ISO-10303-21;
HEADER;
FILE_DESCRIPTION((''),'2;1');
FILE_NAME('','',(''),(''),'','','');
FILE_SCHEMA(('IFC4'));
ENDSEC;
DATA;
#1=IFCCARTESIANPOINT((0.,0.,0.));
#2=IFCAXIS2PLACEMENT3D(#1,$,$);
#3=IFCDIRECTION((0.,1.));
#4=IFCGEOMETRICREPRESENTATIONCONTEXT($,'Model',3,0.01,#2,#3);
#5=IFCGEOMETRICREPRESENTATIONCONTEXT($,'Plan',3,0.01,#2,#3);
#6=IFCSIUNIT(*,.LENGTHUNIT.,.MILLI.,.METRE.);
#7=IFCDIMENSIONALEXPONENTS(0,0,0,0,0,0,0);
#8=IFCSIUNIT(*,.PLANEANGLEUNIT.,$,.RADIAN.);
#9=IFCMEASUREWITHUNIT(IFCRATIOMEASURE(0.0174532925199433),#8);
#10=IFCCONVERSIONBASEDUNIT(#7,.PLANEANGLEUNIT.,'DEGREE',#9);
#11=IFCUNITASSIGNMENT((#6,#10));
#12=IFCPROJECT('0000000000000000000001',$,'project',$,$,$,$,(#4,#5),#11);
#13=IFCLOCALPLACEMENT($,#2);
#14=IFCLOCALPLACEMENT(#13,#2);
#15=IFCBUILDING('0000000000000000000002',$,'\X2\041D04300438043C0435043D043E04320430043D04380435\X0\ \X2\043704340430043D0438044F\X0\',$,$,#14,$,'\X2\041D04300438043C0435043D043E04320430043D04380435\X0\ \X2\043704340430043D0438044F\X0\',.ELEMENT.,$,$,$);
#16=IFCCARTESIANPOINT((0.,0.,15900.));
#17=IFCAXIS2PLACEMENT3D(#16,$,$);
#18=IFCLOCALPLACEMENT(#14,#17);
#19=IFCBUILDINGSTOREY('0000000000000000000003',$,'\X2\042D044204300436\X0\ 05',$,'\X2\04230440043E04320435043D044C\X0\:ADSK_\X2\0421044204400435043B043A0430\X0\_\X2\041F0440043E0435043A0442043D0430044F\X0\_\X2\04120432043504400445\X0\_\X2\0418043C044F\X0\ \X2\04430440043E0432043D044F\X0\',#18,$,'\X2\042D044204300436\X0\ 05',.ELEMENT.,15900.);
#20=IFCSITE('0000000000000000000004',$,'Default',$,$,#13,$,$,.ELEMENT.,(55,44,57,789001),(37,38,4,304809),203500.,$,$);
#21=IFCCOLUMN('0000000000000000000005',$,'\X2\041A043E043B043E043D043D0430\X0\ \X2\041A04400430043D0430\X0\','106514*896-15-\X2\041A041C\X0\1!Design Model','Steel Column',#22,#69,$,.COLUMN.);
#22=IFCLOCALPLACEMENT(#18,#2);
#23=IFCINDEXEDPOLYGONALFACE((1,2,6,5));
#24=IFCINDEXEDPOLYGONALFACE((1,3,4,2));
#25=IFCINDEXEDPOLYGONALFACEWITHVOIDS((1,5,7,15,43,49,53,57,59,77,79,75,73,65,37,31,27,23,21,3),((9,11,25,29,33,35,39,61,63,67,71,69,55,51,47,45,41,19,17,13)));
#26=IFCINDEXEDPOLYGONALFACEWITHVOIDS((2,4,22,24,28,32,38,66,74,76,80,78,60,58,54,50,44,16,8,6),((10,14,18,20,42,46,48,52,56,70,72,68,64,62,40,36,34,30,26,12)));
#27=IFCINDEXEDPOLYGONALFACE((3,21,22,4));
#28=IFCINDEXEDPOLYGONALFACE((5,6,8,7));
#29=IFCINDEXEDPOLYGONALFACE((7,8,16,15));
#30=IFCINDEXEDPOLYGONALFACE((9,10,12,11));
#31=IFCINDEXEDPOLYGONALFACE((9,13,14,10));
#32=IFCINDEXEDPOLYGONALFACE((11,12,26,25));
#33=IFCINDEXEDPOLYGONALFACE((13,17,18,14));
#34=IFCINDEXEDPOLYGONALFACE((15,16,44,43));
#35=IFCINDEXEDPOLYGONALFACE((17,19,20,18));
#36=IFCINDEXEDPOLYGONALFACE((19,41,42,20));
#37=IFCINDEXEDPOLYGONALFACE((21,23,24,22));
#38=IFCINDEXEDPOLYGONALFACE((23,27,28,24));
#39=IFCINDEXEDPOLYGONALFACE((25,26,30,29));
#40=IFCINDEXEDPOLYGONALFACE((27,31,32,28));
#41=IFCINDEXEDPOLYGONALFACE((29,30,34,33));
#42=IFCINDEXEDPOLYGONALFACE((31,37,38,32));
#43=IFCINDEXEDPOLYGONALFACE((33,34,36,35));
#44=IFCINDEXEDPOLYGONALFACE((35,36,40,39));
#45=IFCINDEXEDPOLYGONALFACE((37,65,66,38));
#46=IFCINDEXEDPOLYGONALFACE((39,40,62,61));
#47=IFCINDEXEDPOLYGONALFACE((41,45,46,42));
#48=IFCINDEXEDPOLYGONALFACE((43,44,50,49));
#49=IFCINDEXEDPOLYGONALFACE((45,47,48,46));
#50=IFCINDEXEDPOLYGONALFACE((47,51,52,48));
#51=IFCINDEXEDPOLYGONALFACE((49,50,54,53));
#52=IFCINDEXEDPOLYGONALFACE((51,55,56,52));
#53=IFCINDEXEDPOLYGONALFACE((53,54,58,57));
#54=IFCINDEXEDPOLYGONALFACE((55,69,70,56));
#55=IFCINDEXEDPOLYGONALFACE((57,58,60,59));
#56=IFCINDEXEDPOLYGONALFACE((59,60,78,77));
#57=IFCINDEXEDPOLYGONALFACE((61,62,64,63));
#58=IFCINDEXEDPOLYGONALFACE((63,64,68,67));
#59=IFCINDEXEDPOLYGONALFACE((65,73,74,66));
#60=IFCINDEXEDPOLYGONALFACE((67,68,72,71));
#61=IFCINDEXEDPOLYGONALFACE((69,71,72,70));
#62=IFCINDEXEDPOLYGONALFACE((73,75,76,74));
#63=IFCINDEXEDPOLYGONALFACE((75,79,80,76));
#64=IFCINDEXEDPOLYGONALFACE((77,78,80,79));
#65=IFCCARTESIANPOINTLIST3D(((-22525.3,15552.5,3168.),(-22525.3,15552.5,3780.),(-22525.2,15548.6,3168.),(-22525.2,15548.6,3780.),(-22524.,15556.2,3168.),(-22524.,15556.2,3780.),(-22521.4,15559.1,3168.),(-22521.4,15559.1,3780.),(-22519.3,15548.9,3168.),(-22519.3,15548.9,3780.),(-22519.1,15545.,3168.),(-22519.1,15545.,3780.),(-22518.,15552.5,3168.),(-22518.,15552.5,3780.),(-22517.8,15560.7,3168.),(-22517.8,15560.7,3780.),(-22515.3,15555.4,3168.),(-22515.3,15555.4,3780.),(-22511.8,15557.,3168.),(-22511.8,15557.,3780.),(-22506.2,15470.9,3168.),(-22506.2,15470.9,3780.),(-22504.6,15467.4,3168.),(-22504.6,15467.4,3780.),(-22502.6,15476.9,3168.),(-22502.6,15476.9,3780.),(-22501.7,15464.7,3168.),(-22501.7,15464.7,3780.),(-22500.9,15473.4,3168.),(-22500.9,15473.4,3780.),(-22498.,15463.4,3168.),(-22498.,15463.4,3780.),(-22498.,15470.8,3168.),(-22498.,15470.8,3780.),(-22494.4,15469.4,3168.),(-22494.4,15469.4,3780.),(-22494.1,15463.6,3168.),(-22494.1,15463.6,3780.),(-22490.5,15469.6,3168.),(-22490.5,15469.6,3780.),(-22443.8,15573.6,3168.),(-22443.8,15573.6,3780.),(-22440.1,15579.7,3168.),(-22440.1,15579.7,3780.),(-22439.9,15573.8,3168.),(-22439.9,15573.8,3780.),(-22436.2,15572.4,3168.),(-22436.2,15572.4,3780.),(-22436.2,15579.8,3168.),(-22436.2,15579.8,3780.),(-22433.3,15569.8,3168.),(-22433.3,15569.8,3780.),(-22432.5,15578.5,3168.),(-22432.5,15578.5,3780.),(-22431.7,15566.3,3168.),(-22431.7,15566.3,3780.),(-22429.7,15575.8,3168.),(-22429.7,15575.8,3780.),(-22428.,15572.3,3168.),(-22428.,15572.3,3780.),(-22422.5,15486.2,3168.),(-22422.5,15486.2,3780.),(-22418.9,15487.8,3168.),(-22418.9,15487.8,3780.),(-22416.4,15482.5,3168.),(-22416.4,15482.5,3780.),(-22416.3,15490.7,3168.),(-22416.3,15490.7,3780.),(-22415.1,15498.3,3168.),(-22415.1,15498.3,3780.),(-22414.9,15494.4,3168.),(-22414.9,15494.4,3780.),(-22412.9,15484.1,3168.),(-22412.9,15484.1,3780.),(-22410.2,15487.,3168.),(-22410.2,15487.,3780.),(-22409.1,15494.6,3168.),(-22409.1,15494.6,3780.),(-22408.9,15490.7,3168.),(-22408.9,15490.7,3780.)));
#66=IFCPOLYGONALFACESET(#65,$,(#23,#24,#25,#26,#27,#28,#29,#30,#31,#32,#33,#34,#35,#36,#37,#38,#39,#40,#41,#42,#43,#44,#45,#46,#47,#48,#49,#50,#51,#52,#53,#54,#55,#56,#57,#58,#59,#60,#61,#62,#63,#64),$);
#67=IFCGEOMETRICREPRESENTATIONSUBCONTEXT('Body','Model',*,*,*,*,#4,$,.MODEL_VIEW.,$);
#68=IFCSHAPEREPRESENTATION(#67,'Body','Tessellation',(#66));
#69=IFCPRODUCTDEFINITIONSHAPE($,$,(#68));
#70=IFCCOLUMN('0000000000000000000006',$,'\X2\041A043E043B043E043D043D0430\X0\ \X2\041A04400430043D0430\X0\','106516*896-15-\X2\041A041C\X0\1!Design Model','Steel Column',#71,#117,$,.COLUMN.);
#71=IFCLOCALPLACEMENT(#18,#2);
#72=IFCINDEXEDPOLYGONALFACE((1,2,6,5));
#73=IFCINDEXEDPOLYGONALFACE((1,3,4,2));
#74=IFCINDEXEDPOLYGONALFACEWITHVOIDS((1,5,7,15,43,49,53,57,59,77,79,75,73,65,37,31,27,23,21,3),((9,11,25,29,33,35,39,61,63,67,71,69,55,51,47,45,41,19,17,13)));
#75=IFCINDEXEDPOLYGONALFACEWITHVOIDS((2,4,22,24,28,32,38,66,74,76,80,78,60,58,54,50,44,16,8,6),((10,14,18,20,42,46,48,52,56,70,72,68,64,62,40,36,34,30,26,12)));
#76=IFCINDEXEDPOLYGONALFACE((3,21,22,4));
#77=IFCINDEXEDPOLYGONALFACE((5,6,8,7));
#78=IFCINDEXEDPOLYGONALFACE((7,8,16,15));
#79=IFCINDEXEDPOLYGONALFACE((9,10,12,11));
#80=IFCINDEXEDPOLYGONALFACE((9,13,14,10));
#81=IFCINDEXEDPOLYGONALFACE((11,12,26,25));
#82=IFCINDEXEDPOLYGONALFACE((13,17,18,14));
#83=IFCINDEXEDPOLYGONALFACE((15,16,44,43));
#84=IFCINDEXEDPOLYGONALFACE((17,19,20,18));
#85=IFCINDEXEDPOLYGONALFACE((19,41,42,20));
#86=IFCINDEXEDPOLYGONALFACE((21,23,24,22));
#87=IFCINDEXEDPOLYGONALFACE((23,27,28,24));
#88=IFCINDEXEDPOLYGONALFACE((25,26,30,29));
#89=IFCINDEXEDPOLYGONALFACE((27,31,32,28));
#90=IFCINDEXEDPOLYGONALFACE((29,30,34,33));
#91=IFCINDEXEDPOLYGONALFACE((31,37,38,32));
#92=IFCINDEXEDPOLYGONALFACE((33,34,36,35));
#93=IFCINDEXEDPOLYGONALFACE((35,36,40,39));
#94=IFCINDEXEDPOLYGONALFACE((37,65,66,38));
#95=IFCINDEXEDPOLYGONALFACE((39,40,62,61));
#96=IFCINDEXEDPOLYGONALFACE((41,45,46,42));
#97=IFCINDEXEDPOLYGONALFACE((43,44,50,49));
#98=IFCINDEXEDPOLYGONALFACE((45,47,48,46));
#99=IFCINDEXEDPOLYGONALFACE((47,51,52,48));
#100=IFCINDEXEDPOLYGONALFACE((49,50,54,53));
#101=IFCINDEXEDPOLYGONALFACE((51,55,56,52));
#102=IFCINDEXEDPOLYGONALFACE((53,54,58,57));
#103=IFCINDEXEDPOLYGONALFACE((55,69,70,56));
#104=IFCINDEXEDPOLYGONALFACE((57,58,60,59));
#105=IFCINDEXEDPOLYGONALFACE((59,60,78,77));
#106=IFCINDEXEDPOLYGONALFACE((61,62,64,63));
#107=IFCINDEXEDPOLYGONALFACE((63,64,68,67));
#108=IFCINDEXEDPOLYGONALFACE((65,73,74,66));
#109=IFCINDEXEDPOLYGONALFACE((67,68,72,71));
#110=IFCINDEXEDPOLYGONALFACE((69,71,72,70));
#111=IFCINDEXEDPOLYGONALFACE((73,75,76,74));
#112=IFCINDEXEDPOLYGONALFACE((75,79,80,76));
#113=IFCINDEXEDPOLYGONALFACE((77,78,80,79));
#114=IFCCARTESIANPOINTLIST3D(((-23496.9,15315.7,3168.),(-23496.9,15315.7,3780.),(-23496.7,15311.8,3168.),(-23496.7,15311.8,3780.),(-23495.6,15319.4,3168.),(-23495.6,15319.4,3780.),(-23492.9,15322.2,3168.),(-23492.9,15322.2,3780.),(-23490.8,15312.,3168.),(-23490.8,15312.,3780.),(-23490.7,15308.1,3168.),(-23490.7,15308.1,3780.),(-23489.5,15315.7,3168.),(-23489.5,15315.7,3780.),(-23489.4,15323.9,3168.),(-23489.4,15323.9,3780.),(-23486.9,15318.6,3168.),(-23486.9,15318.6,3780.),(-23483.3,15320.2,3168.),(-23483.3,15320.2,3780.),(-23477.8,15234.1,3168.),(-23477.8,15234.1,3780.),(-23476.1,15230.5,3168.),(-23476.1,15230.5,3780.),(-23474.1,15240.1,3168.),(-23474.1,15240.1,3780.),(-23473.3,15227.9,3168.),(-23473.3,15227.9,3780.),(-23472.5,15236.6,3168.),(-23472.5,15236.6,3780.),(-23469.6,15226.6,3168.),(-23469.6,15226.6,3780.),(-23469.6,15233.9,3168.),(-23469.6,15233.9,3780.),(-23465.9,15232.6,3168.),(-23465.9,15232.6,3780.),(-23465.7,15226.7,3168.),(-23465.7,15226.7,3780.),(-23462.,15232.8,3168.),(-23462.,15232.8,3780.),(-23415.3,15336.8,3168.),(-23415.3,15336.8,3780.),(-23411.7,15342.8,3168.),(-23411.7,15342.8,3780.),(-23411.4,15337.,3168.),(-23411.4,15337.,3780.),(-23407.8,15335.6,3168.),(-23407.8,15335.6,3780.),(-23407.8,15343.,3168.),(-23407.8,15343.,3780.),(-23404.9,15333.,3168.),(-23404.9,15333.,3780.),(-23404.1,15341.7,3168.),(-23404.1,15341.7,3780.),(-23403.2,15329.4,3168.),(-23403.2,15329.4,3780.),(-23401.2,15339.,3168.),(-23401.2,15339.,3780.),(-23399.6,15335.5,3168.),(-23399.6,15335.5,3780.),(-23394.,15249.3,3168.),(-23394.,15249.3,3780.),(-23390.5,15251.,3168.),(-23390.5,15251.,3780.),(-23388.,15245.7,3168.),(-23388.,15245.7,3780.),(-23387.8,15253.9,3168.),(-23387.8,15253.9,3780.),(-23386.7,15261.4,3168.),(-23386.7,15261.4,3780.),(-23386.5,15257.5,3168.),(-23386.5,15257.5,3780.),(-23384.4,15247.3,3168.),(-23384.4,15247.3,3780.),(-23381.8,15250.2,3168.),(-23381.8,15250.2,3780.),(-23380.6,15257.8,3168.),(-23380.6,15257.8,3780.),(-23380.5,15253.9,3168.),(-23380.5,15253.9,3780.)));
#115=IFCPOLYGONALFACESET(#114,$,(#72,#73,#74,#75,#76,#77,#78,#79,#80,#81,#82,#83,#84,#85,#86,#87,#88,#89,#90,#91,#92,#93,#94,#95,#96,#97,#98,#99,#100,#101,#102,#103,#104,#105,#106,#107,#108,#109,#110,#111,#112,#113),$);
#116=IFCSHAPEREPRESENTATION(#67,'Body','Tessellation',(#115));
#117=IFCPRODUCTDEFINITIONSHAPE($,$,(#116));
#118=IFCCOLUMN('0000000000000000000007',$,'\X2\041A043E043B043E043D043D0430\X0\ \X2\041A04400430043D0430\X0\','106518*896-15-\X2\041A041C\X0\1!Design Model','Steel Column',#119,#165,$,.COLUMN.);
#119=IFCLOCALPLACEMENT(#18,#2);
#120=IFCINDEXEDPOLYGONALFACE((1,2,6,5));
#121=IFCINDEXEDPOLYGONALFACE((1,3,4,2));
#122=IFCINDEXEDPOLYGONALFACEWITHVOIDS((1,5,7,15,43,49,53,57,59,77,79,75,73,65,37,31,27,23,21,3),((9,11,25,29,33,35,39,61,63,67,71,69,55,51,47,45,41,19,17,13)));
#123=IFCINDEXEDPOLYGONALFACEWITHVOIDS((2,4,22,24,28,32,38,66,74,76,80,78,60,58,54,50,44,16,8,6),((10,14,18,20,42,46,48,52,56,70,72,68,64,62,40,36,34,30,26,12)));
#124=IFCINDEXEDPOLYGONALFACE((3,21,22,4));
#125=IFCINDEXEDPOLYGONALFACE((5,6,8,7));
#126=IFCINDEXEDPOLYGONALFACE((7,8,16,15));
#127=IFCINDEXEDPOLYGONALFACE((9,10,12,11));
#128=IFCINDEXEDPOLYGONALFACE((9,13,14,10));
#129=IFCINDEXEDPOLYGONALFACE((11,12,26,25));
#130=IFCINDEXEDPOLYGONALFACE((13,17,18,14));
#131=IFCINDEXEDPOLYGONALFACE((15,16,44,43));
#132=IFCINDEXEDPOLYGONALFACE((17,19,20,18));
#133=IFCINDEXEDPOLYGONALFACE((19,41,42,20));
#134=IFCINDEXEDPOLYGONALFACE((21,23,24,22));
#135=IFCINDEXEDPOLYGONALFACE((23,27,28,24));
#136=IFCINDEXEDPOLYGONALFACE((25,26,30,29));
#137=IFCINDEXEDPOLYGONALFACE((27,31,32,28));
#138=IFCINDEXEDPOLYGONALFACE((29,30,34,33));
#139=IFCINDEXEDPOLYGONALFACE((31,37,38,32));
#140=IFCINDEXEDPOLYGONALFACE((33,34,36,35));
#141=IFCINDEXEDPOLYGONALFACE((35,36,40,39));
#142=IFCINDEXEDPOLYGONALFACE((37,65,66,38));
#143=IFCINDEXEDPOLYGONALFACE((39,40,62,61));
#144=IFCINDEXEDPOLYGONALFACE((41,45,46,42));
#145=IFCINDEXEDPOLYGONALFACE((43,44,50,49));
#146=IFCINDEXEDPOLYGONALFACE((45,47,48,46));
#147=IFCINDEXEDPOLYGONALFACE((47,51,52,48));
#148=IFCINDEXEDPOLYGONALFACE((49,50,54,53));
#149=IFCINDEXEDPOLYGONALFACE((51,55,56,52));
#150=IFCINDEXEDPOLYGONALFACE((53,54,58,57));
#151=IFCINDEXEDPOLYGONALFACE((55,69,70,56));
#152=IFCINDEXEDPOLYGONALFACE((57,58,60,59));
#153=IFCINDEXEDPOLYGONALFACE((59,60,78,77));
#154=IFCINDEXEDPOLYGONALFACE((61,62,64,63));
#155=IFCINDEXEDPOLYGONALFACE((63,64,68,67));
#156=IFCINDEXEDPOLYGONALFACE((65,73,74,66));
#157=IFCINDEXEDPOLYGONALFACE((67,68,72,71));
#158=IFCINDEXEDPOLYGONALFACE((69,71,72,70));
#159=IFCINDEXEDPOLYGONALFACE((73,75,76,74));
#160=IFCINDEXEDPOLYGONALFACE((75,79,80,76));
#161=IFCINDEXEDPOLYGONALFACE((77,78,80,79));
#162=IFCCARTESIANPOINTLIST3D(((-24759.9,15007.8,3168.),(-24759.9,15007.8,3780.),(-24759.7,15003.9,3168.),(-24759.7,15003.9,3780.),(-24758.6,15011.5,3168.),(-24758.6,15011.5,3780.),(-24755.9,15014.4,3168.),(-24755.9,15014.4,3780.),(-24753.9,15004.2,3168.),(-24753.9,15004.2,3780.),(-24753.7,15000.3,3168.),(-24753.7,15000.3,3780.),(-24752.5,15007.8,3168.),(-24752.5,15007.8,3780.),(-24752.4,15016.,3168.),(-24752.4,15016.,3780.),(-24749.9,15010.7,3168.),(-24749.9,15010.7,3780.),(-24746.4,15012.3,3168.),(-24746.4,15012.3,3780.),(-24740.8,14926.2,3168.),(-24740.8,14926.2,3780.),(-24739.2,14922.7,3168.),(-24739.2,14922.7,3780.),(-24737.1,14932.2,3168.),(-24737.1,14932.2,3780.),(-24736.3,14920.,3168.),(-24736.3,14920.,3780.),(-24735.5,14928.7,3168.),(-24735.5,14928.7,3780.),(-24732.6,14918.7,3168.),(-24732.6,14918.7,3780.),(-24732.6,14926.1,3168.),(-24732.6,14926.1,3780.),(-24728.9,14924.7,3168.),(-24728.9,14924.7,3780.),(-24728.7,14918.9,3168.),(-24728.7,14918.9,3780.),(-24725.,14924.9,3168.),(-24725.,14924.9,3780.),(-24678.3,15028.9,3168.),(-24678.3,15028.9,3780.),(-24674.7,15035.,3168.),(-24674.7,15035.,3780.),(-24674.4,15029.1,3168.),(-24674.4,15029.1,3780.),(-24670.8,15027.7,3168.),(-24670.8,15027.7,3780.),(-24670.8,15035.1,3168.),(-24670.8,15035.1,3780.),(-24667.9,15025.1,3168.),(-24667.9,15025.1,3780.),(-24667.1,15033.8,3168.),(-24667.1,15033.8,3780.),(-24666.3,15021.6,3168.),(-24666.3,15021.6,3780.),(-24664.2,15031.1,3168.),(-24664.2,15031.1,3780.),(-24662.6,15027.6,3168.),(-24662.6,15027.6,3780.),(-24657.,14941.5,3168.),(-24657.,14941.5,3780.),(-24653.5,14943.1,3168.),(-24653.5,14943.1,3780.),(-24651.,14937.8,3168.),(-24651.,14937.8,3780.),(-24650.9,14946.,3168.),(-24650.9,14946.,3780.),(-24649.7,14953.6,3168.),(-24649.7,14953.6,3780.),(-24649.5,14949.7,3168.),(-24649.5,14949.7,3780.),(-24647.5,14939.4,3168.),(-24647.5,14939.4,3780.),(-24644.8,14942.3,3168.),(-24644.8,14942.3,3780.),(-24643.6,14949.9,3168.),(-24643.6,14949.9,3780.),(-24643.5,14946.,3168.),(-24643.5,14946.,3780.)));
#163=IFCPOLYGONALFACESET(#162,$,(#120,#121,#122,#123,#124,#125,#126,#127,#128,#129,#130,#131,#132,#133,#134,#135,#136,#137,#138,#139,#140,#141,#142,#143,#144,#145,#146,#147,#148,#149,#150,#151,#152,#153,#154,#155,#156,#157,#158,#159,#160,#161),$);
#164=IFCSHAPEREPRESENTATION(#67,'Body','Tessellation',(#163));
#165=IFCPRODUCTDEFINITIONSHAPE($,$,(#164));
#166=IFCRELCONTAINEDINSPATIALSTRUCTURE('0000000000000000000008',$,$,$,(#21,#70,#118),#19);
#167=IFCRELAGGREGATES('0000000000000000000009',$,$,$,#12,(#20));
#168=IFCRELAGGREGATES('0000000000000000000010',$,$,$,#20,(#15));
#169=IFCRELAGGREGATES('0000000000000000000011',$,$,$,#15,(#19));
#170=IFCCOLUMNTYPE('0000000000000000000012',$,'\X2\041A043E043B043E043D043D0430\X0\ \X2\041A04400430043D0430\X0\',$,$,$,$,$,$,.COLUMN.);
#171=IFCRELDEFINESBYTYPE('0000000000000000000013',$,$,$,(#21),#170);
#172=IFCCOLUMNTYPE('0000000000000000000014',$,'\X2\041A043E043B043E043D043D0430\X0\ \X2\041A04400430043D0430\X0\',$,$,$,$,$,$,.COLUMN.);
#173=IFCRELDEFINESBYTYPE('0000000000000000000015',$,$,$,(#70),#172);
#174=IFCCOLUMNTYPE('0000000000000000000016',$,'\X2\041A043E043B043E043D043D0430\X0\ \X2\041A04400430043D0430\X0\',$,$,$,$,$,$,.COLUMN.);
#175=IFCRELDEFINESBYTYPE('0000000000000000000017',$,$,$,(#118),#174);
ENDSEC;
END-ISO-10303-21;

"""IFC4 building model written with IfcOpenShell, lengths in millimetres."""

from ifc_helpers import new_model, entity, si_unit, converted_unit, direction, frame, origin, place, context, subcontext, project, spatial, indexed_curve, outline, extrude, type_object, element, save


model = new_model("IFC4")

# Units and contexts
model_context = context("Model", 3, precision=0.01, world=origin(), true_north=direction((0.0, 1.0)))
plan_context = context("Plan", 3, precision=0.01, world=origin(), true_north=direction((0.0, 1.0)))
body_context = subcontext(model_context, "Body", "Model", "MODEL_VIEW")
ifc_project = project(units=[si_unit("LENGTHUNIT", "METRE", prefix="MILLI"), converted_unit("PLANEANGLEUNIT", "DEGREE", entity("IfcRatioMeasure", 0.0174532925199433), si_unit("PLANEANGLEUNIT", "RADIAN"), dimensions=[0, 0, 0, 0, 0, 0, 0])], contexts=[model_context, plan_context])

# Site, building, storey
site_placement = place(None, origin())
site = spatial("IfcSite", under=ifc_project, at=site_placement, Name="Default", CompositionType="ELEMENT", RefLatitude=(55, 44, 57, 789001), RefLongitude=(37, 38, 4, 304809), RefElevation=203500.0)
building_placement = place(site_placement, origin())
building = spatial("IfcBuilding", under=site, at=building_placement, Name="Наименование здания", LongName="Наименование здания", CompositionType="ELEMENT")
storey_placement = place(building_placement, frame((0.0, 0.0, 15900.0)))
storey = spatial("IfcBuildingStorey", under=building, at=storey_placement, Name="Этаж 05", ObjectType="Уровень:ADSK_Стрелка_Проектная_Вверх_Имя уровня", LongName="Этаж 05", CompositionType="ELEMENT", Elevation=15900.0)

# Columns
column_type_1 = type_object("IfcColumnType", Name="Колонна Крана", PredefinedType="COLUMN")
column_1_placement = place(storey_placement, origin())
element("IfcColumn", 1, at=column_1_placement, inside=storey, type_object=column_type_1, Name="Колонна Крана", Description="106514*896-15-КМ1!Design Model", ObjectType="Steel Column", PredefinedType="COLUMN", context=body_context, shape_type="SweptSolid", body=[
    extrude(outline(indexed_curve([(29.5, -56.8), (33.4, -56.8), (37.0, -55.3), (39.7, -52.6), (41.2, -49.0), (56.8, 29.5), (56.8, 33.4), (55.3, 37.0), (52.6, 39.7), (49.0, 41.2), (-29.5, 56.8), (-33.4, 56.8), (-37.0, 55.3), (-39.7, 52.6), (-41.2, 49.0), (-56.8, -29.5), (-56.8, -33.4), (-55.3, -37.0), (-52.6, -39.7), (-49.0, -41.2), (29.5, -56.8)], self_intersect=False), holes=[indexed_curve([(-43.1, -37.3), (-46.7, -35.8), (-49.5, -33.1), (-51.0, -29.5), (-51.0, -25.5), (-37.3, 43.1), (-35.8, 46.7), (-33.1, 49.5), (-29.5, 51.0), (-25.5, 51.0), (43.1, 37.3), (46.7, 35.8), (49.5, 33.1), (51.0, 29.5), (51.0, 25.5), (37.3, -43.1), (35.8, -46.7), (33.1, -49.5), (29.5, -51.0), (25.5, -51.0), (-43.1, -37.3)], self_intersect=False)]), frame((-22467.1, 15521.6, 3168.0), z_axis=(0.0, 0.0, 1.0), x_axis=(0.906681, 0.421816, 0.0)), (0.0, 0.0, 1.0), 612.0),
])
column_type_2 = type_object("IfcColumnType", Name="Колонна Крана", PredefinedType="COLUMN")
column_2_placement = place(storey_placement, origin())
element("IfcColumn", 2, at=column_2_placement, inside=storey, type_object=column_type_2, Name="Колонна Крана", Description="106516*896-15-КМ1!Design Model", ObjectType="Steel Column", PredefinedType="COLUMN", context=body_context, shape_type="SweptSolid", body=[
    extrude(outline(indexed_curve([(29.5, -56.8), (33.4, -56.8), (37.0, -55.3), (39.7, -52.6), (41.2, -49.0), (56.8, 29.5), (56.8, 33.4), (55.3, 37.0), (52.6, 39.7), (49.0, 41.2), (-29.5, 56.8), (-33.4, 56.8), (-37.0, 55.3), (-39.7, 52.6), (-41.2, 49.0), (-56.8, -29.5), (-56.8, -33.4), (-55.3, -37.0), (-52.6, -39.7), (-49.0, -41.2), (29.5, -56.8)], self_intersect=False), holes=[indexed_curve([(-43.1, -37.3), (-46.7, -35.8), (-49.5, -33.1), (-51.0, -29.5), (-51.0, -25.5), (-37.3, 43.1), (-35.8, 46.7), (-33.1, 49.5), (-29.5, 51.0), (-25.5, 51.0), (43.1, 37.3), (46.7, 35.8), (49.5, 33.1), (51.0, 29.5), (51.0, 25.5), (37.3, -43.1), (35.8, -46.7), (33.1, -49.5), (29.5, -51.0), (25.5, -51.0), (-43.1, -37.3)], self_intersect=False)]), frame((-23438.7, 15284.8, 3168.0), z_axis=(0.0, 0.0, 1.0), x_axis=(0.906681, 0.421816, 0.0)), (0.0, 0.0, 1.0), 612.0),
])
column_type_3 = type_object("IfcColumnType", Name="Колонна Крана", PredefinedType="COLUMN")
column_3_placement = place(storey_placement, origin())
element("IfcColumn", 3, at=column_3_placement, inside=storey, type_object=column_type_3, Name="Колонна Крана", Description="106518*896-15-КМ1!Design Model", ObjectType="Steel Column", PredefinedType="COLUMN", context=body_context, shape_type="SweptSolid", body=[
    extrude(outline(indexed_curve([(29.5, -56.8), (33.4, -56.8), (37.0, -55.3), (39.7, -52.6), (41.2, -49.0), (56.8, 29.5), (56.8, 33.4), (55.3, 37.0), (52.6, 39.7), (49.0, 41.2), (-29.5, 56.8), (-33.4, 56.8), (-37.0, 55.3), (-39.7, 52.6), (-41.2, 49.0), (-56.8, -29.5), (-56.8, -33.4), (-55.3, -37.0), (-52.6, -39.7), (-49.0, -41.2), (29.5, -56.8)], self_intersect=False), holes=[indexed_curve([(-43.1, -37.3), (-46.7, -35.8), (-49.5, -33.1), (-51.0, -29.5), (-51.0, -25.5), (-37.3, 43.1), (-35.8, 46.7), (-33.1, 49.5), (-29.5, 51.0), (-25.5, 51.0), (43.1, 37.3), (46.7, 35.8), (49.5, 33.1), (51.0, 29.5), (51.0, 25.5), (37.3, -43.1), (35.8, -46.7), (33.1, -49.5), (29.5, -51.0), (25.5, -51.0), (-43.1, -37.3)], self_intersect=False)]), frame((-24701.7, 14976.9, 3168.0), z_axis=(0.0, 0.0, 1.0), x_axis=(0.906681, 0.421816, 0.0)), (0.0, 0.0, 1.0), 612.0),
])

save(model, "model.ifc")
